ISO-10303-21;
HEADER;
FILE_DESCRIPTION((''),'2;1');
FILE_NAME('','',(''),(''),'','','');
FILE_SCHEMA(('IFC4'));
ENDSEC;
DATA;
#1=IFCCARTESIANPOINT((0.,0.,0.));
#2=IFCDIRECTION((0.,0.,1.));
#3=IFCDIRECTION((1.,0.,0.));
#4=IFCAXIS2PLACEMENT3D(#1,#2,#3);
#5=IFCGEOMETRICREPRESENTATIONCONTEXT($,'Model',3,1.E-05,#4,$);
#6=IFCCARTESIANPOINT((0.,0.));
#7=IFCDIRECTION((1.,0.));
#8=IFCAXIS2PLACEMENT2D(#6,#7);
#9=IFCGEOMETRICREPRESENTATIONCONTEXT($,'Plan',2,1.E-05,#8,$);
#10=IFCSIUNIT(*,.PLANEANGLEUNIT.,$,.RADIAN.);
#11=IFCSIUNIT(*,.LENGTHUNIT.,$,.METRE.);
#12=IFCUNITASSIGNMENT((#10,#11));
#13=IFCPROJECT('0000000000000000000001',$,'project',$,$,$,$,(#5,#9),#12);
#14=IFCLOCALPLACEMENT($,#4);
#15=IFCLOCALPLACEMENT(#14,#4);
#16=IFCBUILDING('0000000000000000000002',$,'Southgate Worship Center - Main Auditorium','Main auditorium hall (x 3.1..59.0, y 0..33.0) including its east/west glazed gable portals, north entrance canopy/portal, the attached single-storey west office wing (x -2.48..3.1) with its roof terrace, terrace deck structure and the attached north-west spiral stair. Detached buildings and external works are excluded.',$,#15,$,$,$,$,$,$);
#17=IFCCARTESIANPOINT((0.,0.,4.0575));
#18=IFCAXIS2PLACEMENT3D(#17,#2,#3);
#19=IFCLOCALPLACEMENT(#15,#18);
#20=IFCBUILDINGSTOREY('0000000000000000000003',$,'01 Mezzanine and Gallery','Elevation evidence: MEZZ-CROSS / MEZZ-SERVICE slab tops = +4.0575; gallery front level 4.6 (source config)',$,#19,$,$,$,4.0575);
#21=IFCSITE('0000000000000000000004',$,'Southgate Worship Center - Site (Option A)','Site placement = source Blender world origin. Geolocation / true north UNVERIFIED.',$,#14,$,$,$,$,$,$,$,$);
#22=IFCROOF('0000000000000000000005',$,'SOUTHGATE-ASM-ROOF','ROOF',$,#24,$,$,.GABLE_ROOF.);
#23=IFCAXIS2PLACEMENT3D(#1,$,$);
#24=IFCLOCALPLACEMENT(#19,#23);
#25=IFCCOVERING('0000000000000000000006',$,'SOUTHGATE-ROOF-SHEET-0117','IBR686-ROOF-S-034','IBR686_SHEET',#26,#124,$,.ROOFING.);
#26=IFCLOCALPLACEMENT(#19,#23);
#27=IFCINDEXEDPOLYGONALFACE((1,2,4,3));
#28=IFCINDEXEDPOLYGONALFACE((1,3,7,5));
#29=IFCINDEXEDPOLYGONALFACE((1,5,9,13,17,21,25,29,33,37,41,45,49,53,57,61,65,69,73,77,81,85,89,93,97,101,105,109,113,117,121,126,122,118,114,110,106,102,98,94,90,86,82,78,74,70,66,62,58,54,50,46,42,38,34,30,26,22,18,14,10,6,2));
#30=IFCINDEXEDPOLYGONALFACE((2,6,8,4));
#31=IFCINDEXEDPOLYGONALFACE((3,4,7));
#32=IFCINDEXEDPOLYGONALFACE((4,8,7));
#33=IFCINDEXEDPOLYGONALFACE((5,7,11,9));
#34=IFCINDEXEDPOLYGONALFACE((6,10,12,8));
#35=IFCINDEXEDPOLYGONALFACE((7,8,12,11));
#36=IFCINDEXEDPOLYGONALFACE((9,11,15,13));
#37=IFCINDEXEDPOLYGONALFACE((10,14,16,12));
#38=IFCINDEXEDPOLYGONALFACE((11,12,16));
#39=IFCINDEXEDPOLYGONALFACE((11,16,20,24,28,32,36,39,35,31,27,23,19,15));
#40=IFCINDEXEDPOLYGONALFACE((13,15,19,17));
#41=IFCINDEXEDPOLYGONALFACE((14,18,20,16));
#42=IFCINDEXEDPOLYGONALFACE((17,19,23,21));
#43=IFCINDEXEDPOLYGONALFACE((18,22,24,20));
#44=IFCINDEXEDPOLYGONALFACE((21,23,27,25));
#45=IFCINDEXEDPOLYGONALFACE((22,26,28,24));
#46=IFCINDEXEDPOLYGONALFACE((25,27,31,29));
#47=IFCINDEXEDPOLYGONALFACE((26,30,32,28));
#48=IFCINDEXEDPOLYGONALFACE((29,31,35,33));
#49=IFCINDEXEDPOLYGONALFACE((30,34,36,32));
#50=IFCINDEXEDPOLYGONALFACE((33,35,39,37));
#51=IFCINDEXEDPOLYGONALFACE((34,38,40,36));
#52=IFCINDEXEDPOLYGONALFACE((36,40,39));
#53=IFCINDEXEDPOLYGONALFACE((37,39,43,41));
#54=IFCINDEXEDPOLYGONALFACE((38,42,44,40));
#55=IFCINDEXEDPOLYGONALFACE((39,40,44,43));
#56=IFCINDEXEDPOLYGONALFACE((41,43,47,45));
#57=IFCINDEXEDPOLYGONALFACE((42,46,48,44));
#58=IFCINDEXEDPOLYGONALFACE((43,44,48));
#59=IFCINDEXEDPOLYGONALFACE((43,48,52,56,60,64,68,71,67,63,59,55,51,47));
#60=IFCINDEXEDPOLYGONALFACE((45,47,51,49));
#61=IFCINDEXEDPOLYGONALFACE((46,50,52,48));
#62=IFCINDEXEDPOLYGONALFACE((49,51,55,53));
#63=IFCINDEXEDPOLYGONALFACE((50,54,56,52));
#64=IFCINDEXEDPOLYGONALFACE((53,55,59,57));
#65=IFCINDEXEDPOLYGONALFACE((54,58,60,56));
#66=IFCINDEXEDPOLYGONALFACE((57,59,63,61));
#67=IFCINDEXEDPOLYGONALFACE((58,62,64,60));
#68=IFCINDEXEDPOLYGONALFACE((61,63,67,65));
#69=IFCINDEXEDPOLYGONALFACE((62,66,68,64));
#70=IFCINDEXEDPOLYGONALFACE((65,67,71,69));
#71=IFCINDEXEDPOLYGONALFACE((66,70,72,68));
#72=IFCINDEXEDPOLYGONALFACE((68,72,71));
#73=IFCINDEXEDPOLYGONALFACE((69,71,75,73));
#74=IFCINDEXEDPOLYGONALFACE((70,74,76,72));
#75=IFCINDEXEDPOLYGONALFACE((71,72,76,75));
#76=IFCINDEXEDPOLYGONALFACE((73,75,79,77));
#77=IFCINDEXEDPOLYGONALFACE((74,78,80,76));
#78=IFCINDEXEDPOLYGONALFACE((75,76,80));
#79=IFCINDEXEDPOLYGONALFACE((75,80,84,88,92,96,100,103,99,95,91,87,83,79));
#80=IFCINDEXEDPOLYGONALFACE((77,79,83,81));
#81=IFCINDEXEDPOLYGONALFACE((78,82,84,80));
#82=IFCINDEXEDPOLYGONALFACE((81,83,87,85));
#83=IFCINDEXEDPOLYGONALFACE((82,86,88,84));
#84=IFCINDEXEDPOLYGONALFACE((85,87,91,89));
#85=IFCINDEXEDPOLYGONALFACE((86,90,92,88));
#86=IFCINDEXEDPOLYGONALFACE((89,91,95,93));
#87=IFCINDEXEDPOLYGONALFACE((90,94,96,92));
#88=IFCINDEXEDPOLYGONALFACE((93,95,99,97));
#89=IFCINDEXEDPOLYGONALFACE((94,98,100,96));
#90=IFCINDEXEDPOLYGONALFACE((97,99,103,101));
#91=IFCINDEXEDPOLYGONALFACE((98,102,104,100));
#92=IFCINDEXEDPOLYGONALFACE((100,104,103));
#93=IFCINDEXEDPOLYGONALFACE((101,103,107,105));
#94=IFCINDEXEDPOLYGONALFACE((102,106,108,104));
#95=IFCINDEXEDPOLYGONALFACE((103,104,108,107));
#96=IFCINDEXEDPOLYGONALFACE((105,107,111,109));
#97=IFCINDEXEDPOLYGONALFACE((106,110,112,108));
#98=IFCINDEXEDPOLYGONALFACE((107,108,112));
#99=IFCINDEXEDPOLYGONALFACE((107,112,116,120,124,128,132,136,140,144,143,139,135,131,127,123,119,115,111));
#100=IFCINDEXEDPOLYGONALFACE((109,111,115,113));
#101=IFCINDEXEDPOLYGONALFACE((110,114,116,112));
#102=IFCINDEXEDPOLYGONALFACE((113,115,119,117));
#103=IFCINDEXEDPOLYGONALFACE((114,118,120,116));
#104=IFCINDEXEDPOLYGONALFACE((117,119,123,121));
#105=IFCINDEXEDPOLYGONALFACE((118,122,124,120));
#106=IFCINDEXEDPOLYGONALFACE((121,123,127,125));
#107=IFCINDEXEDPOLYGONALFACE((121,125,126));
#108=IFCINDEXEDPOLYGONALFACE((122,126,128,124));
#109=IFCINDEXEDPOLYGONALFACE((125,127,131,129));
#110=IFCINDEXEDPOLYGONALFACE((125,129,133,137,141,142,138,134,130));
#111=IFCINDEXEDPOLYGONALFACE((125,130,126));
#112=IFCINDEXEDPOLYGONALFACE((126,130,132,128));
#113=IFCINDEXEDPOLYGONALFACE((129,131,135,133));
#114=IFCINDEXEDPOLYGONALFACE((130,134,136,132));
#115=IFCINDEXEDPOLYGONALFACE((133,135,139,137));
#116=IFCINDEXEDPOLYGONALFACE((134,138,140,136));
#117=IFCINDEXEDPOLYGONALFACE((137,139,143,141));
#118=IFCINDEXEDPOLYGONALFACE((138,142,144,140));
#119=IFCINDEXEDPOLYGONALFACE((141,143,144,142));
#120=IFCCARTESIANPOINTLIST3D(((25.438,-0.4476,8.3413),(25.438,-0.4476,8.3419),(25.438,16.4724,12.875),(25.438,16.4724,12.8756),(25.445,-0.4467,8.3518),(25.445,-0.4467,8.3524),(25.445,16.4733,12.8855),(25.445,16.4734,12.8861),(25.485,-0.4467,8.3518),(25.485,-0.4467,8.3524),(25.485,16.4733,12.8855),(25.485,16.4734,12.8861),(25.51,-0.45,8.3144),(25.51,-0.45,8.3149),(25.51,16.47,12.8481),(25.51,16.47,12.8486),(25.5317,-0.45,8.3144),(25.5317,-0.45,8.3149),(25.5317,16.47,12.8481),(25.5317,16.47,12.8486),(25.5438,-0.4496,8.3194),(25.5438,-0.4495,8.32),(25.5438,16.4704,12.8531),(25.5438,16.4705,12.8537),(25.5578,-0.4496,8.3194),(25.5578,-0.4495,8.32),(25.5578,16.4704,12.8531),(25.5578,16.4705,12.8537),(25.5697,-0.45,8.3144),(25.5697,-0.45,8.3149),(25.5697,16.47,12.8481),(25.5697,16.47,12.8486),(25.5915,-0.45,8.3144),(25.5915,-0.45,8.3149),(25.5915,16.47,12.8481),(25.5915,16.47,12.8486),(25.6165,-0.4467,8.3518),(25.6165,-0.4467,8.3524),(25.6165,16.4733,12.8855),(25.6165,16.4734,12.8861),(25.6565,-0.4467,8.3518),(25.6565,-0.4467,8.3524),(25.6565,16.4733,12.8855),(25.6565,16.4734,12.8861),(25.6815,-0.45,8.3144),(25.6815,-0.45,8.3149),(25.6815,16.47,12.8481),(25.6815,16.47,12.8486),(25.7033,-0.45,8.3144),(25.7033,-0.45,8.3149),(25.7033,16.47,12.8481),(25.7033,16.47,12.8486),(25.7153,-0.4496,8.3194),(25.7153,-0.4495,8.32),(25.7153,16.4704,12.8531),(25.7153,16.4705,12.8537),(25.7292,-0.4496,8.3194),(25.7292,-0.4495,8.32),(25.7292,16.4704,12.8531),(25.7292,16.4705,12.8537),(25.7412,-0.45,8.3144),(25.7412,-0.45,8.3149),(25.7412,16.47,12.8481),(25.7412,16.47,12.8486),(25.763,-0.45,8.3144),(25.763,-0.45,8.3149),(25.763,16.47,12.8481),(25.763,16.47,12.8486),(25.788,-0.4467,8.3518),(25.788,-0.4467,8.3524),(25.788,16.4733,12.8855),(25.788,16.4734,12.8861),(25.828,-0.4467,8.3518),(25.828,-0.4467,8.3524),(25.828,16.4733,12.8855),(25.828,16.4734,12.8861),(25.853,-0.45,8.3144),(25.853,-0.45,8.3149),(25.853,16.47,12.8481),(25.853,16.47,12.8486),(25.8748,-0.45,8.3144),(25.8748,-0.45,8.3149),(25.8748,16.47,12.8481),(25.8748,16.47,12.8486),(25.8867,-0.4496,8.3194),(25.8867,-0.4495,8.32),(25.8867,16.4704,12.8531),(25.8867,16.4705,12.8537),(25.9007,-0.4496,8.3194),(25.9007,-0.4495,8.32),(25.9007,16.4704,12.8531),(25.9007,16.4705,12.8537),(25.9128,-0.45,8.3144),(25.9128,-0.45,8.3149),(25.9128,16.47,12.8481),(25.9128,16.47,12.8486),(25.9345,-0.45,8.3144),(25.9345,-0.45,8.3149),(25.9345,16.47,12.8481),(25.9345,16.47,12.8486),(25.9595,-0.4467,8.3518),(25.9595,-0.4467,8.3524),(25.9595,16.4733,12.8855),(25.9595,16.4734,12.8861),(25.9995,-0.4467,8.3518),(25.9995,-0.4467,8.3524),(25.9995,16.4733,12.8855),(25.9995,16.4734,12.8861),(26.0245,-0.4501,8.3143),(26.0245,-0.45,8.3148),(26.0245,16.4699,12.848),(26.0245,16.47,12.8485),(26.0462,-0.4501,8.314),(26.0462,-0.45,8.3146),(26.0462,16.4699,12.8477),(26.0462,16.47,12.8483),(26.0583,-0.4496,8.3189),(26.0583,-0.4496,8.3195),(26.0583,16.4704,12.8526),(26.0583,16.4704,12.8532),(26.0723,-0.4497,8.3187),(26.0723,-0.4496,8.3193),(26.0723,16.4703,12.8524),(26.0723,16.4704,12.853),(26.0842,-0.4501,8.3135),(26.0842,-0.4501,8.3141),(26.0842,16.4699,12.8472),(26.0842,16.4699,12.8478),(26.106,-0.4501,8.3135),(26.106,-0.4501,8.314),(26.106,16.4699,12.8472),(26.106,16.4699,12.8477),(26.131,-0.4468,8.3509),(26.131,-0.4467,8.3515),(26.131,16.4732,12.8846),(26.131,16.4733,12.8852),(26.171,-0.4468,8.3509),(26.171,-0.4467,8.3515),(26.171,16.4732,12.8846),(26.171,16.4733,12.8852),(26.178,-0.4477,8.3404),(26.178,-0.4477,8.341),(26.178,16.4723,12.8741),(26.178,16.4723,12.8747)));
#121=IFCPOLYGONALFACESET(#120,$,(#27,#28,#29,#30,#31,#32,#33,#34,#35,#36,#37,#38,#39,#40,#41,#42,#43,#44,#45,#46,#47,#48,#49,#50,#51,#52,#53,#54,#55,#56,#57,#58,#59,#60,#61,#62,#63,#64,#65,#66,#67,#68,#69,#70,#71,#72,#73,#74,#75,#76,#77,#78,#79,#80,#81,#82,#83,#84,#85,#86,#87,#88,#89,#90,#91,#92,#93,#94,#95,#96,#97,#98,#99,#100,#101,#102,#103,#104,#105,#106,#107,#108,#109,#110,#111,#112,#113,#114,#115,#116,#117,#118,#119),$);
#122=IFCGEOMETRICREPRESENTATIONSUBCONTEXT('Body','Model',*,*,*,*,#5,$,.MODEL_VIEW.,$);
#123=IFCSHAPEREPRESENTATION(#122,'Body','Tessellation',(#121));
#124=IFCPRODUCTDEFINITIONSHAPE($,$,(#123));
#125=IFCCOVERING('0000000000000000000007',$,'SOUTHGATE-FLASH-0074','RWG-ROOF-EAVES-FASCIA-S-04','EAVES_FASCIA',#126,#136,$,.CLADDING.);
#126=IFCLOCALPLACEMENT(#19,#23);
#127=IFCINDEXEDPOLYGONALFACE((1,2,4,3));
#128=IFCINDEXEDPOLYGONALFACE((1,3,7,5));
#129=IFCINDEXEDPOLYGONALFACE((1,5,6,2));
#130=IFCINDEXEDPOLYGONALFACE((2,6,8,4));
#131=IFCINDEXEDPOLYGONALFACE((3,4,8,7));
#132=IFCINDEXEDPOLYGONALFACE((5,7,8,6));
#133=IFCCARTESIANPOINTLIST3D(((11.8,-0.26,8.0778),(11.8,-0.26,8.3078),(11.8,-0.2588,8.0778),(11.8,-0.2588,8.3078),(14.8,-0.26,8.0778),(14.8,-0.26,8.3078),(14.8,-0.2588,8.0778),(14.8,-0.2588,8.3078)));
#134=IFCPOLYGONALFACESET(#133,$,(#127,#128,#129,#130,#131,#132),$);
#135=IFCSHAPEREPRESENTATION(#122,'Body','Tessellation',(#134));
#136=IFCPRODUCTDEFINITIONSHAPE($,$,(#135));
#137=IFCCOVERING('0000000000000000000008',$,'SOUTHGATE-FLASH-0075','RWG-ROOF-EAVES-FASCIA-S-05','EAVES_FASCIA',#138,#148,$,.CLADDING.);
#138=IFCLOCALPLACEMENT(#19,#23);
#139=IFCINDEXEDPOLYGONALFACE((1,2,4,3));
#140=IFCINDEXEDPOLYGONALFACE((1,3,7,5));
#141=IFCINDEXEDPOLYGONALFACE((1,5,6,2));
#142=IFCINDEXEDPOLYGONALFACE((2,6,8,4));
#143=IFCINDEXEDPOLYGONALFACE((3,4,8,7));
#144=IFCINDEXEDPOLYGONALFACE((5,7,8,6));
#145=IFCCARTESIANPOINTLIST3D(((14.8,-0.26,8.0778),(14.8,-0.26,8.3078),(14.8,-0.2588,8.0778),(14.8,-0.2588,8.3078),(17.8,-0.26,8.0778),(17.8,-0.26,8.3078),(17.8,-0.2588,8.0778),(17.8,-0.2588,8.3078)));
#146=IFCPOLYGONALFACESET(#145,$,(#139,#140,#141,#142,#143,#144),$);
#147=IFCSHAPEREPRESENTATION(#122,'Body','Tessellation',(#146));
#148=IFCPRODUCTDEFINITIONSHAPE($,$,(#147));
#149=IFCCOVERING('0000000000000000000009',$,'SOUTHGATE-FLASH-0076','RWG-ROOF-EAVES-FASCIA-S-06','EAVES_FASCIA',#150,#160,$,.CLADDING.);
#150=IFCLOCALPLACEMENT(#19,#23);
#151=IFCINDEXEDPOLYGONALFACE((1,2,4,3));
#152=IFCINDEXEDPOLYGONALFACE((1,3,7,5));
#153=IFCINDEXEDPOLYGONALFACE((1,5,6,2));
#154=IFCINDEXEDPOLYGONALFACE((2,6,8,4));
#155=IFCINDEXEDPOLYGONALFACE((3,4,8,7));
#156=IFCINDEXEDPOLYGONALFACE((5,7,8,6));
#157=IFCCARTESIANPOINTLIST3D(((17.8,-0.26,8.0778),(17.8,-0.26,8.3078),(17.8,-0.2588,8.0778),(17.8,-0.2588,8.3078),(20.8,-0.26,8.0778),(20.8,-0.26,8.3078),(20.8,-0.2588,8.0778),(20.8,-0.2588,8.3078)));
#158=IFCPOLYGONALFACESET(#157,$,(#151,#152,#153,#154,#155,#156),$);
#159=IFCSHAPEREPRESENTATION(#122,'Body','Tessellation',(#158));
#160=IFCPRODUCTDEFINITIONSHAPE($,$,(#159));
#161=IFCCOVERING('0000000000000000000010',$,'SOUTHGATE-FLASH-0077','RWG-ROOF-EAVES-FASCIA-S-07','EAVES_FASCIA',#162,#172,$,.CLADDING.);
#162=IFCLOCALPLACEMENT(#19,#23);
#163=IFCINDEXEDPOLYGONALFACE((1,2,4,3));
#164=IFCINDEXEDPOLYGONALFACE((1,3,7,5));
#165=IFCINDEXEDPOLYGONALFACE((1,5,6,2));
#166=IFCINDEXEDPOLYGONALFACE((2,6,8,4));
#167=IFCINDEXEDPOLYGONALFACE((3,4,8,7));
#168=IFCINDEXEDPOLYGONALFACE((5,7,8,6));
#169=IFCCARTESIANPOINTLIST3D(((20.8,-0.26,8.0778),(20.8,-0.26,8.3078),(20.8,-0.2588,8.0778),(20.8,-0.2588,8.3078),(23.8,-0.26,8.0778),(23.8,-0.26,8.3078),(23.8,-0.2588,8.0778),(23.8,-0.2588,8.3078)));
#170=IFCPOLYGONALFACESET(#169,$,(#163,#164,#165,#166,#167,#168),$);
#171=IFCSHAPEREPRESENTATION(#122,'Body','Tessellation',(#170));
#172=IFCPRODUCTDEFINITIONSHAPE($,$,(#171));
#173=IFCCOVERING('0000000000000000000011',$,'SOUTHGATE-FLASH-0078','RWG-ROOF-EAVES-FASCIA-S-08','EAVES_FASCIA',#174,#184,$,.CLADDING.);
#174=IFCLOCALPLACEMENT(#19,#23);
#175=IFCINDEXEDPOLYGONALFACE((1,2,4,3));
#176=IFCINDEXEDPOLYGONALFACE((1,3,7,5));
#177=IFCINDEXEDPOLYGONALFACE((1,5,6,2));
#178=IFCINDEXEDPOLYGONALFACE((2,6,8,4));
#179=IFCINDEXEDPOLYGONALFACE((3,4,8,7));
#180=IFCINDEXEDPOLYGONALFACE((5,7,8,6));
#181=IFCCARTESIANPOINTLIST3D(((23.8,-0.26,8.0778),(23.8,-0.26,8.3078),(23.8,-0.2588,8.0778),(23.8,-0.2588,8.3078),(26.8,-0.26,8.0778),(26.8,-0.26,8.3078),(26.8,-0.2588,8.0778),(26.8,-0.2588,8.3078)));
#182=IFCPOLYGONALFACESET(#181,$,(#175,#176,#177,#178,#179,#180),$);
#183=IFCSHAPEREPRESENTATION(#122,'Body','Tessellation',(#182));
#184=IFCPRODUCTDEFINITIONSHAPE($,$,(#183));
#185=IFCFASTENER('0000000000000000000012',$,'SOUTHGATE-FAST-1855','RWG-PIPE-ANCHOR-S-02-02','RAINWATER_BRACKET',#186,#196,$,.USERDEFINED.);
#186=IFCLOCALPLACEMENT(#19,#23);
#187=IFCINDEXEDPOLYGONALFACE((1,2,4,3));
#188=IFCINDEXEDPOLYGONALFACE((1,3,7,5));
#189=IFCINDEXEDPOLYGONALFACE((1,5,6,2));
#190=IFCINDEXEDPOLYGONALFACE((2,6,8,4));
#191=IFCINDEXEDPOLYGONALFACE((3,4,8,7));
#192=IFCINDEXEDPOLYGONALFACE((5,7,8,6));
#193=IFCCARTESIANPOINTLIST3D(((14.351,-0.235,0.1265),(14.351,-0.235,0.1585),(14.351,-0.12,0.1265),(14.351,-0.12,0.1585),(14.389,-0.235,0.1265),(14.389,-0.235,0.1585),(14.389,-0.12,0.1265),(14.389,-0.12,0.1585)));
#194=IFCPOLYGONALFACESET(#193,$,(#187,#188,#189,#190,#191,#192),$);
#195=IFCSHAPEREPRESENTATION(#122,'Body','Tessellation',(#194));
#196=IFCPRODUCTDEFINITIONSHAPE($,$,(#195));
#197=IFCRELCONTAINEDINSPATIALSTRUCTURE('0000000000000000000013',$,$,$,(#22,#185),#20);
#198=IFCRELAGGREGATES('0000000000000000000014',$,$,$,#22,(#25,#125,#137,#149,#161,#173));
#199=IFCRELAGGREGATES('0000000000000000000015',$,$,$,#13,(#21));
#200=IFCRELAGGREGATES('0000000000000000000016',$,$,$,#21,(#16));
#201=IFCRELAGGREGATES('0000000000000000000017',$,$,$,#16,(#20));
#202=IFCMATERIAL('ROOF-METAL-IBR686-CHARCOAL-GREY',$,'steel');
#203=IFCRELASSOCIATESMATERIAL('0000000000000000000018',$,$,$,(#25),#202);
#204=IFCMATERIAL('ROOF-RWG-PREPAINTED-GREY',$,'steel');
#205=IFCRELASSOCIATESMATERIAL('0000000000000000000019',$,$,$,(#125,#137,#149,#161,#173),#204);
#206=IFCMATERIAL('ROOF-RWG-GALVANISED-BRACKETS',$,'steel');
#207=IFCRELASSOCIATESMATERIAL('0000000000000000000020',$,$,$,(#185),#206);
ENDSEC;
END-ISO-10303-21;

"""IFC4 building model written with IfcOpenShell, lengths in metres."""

from ifc_helpers import new_model, si_unit, frame, origin_with_axes, origin_2d, origin_2d_with_axis, place, context, subcontext, project, spatial, indexed_curve, rectangle, outline, extrude, clip, halfspace, material, element, aggregate, save


model = new_model("IFC4")

# Units and contexts
model_context = context("Model", 3, precision=1e-05, world=origin_with_axes())
plan_context = context("Plan", 2, precision=1e-05, world=origin_2d_with_axis())
body_context = subcontext(model_context, "Body", "Model", "MODEL_VIEW")
ifc_project = project(units=[si_unit("PLANEANGLEUNIT", "RADIAN"), si_unit("LENGTHUNIT", "METRE")], contexts=[model_context, plan_context])

# Site, building, storey
site_placement = place(None, origin_with_axes())
site = spatial("IfcSite", under=ifc_project, at=site_placement, Name="Southgate Worship Center - Site (Option A)", Description="Site placement = source Blender world origin. Geolocation / true north UNVERIFIED.")
building_placement = place(site_placement, origin_with_axes())
building = spatial("IfcBuilding", under=site, at=building_placement, Name="Southgate Worship Center - Main Auditorium", Description="Main auditorium hall (x 3.1..59.0, y 0..33.0) including its east/west glazed gable portals, north entrance canopy/portal, the attached single-storey west office wing (x -2.48..3.1) with its roof terrace, terrace deck structure and the attached north-west spiral stair. Detached buildings and external works are excluded.")
storey_placement = place(building_placement, frame((0.0, 0.0, 4.0575), z_axis=(0.0, 0.0, 1.0), x_axis=(1.0, 0.0, 0.0)))
storey = spatial("IfcBuildingStorey", under=building, at=storey_placement, Name="01 Mezzanine and Gallery", Description="Elevation evidence: MEZZ-CROSS / MEZZ-SERVICE slab tops = +4.0575; gallery front level 4.6 (source config)", Elevation=4.0575)

# Roof, coverings
roof_placement = place(storey_placement, origin_with_axes())
roof = element("IfcRoof", 1, at=roof_placement, inside=storey, Name="SOUTHGATE-ASM-ROOF", Description="ROOF", PredefinedType="GABLE_ROOF")
ifc_material_1 = material(Name="ROOF-METAL-IBR686-CHARCOAL-GREY", Category="steel")
covering_1_placement = place(roof_placement, frame((25.438, -0.4501, 8.3135), z_axis=(0.0, 0.0, 1.0), x_axis=(1.0, 0.0, 0.0)))
covering_1 = element("IfcCovering", 2, at=covering_1_placement, material=ifc_material_1, Name="SOUTHGATE-ROOF-SHEET-0117", Description="IBR686-ROOF-S-034", ObjectType="IBR686_SHEET", PredefinedType="ROOFING", context=body_context, shape_type="Clipping", body=[
    clip(clip(extrude(outline(indexed_curve([(0.0, 0.0), (0.025, 0.0353), (0.065, 0.0353), (0.072, 0.0254), (0.072, 0.0259), (0.065, 0.0358), (0.025, 0.0358), (0.0, 0.0005), (-0.0217, 0.0005), (-0.0338, 0.0053), (-0.0478, 0.0053), (-0.0597, 0.0005), (-0.0815, 0.0005), (-0.1065, 0.0358), (-0.1465, 0.0358), (-0.1715, 0.0005), (-0.1933, 0.0005), (-0.2052, 0.0053), (-0.2192, 0.0053), (-0.2312, 0.0005), (-0.253, 0.0005), (-0.278, 0.0358), (-0.318, 0.0358), (-0.343, 0.0005), (-0.3647, 0.0005), (-0.3767, 0.0053), (-0.3907, 0.0053), (-0.4028, 0.0005), (-0.4245, 0.0005), (-0.4495, 0.0358), (-0.4895, 0.0358), (-0.5145, 0.0004), (-0.5362, 0.0002), (-0.5483, 0.0048), (-0.5623, 0.0046), (-0.5742, -0.0003), (-0.596, -0.0004), (-0.621, 0.0349), (-0.661, 0.0349), (-0.668, 0.0251), (-0.668, 0.0246), (-0.661, 0.0344), (-0.621, 0.0344), (-0.596, -0.0009), (-0.5742, -0.0008), (-0.5623, 0.0041), (-0.5483, 0.0043), (-0.5362, -0.0003), (-0.5145, -0.0001), (-0.4895, 0.0353), (-0.4495, 0.0353), (-0.4245, 0.0), (-0.4028, 0.0), (-0.3907, 0.0048), (-0.3767, 0.0048), (-0.3647, 0.0), (-0.343, 0.0), (-0.318, 0.0353), (-0.278, 0.0353), (-0.253, 0.0), (-0.2312, 0.0), (-0.2192, 0.0048), (-0.2052, 0.0048), (-0.1933, 0.0), (-0.1715, 0.0), (-0.1465, 0.0353), (-0.1065, 0.0353), (-0.0815, 0.0), (-0.0597, 0.0), (-0.0478, 0.0048), (-0.0338, 0.0048), (-0.0217, 0.0), (0.0, 0.0)], self_intersect=False)), frame((0.072, -0.0003, 0.0008), z_axis=(0.0, 0.965926, 0.258819), x_axis=(-1.0, 0.0, 0.0)), (0.0, 0.0, 1.0), 17.5303), halfspace(frame((0.37, 0.0012, 0.014), z_axis=(0.0, -0.996022, 0.089113), x_axis=(1.0, 0.0, 0.0)), False)), halfspace(frame((0.37, 16.9212, 4.5477), z_axis=(0.0, 0.996021, -0.089119), x_axis=(-1.0, 0.0, 0.0)), False)),
])
ifc_material_2 = material(Name="ROOF-RWG-PREPAINTED-GREY", Category="steel")
covering_2_placement = place(roof_placement, frame((11.8, -0.26, 8.0778), z_axis=(0.0, 0.0, 1.0), x_axis=(1.0, 0.0, 0.0)))
covering_2 = element("IfcCovering", 3, at=covering_2_placement, material=ifc_material_2, Name="SOUTHGATE-FLASH-0074", Description="RWG-ROOF-EAVES-FASCIA-S-04", ObjectType="EAVES_FASCIA", PredefinedType="CLADDING", context=body_context, shape_type="SweptSolid", body=[
    extrude(rectangle(XDim=0.0012, YDim=3.0, at=origin_2d()), frame((1.5, 0.0006, 0.0), z_axis=(0.0, 0.0, 1.0), x_axis=(0.0, -1.0, 0.0)), (0.0, 0.0, 1.0), 0.23),
])
covering_3_placement = place(roof_placement, frame((14.8, -0.26, 8.0778), z_axis=(0.0, 0.0, 1.0), x_axis=(1.0, 0.0, 0.0)))
covering_3 = element("IfcCovering", 4, at=covering_3_placement, material=ifc_material_2, Name="SOUTHGATE-FLASH-0075", Description="RWG-ROOF-EAVES-FASCIA-S-05", ObjectType="EAVES_FASCIA", PredefinedType="CLADDING", context=body_context, shape_type="SweptSolid", body=[
    extrude(rectangle(XDim=0.0012, YDim=3.0, at=origin_2d()), frame((1.5, 0.0006, 0.0), z_axis=(0.0, 0.0, 1.0), x_axis=(0.0, -1.0, 0.0)), (0.0, 0.0, 1.0), 0.23),
])
covering_4_placement = place(roof_placement, frame((17.8, -0.26, 8.0778), z_axis=(0.0, 0.0, 1.0), x_axis=(1.0, 0.0, 0.0)))
covering_4 = element("IfcCovering", 5, at=covering_4_placement, material=ifc_material_2, Name="SOUTHGATE-FLASH-0076", Description="RWG-ROOF-EAVES-FASCIA-S-06", ObjectType="EAVES_FASCIA", PredefinedType="CLADDING", context=body_context, shape_type="SweptSolid", body=[
    extrude(rectangle(XDim=0.0012, YDim=3.0, at=origin_2d()), frame((1.5, 0.0006, 0.0), z_axis=(0.0, 0.0, 1.0), x_axis=(0.0, -1.0, 0.0)), (0.0, 0.0, 1.0), 0.23),
])
covering_5_placement = place(roof_placement, frame((20.8, -0.26, 8.0778), z_axis=(0.0, 0.0, 1.0), x_axis=(1.0, 0.0, 0.0)))
covering_5 = element("IfcCovering", 6, at=covering_5_placement, material=ifc_material_2, Name="SOUTHGATE-FLASH-0077", Description="RWG-ROOF-EAVES-FASCIA-S-07", ObjectType="EAVES_FASCIA", PredefinedType="CLADDING", context=body_context, shape_type="SweptSolid", body=[
    extrude(rectangle(XDim=0.0012, YDim=3.0, at=origin_2d()), frame((1.5, 0.0006, 0.0), z_axis=(0.0, 0.0, 1.0), x_axis=(0.0, -1.0, 0.0)), (0.0, 0.0, 1.0), 0.23),
])
covering_6_placement = place(roof_placement, frame((23.8, -0.26, 8.0778), z_axis=(0.0, 0.0, 1.0), x_axis=(1.0, 0.0, 0.0)))
covering_6 = element("IfcCovering", 7, at=covering_6_placement, material=ifc_material_2, Name="SOUTHGATE-FLASH-0078", Description="RWG-ROOF-EAVES-FASCIA-S-08", ObjectType="EAVES_FASCIA", PredefinedType="CLADDING", context=body_context, shape_type="SweptSolid", body=[
    extrude(rectangle(XDim=0.0012, YDim=3.0, at=origin_2d()), frame((1.5, 0.0006, 0.0), z_axis=(0.0, 0.0, 1.0), x_axis=(0.0, -1.0, 0.0)), (0.0, 0.0, 1.0), 0.23),
])
aggregate(roof, [covering_1, covering_2, covering_3, covering_4, covering_5, covering_6])

# Fastener
ifc_material_3 = material(Name="ROOF-RWG-GALVANISED-BRACKETS", Category="steel")
fastener_1_placement = place(storey_placement, frame((14.351, -0.235, 0.1265), z_axis=(0.0, 0.0, 1.0), x_axis=(1.0, 0.0, 0.0)))
element("IfcFastener", 8, at=fastener_1_placement, inside=storey, material=ifc_material_3, Name="SOUTHGATE-FAST-1855", Description="RWG-PIPE-ANCHOR-S-02-02", ObjectType="RAINWATER_BRACKET", PredefinedType="USERDEFINED", context=body_context, shape_type="SweptSolid", body=[
    extrude(rectangle(XDim=0.038, YDim=0.115, at=origin_2d()), frame((0.019, 0.0575, 0.0), z_axis=(0.0, 0.0, 1.0), x_axis=(1.0, 0.0, 0.0)), (0.0, 0.0, 1.0), 0.032),
])

save(model, "model.ifc")
